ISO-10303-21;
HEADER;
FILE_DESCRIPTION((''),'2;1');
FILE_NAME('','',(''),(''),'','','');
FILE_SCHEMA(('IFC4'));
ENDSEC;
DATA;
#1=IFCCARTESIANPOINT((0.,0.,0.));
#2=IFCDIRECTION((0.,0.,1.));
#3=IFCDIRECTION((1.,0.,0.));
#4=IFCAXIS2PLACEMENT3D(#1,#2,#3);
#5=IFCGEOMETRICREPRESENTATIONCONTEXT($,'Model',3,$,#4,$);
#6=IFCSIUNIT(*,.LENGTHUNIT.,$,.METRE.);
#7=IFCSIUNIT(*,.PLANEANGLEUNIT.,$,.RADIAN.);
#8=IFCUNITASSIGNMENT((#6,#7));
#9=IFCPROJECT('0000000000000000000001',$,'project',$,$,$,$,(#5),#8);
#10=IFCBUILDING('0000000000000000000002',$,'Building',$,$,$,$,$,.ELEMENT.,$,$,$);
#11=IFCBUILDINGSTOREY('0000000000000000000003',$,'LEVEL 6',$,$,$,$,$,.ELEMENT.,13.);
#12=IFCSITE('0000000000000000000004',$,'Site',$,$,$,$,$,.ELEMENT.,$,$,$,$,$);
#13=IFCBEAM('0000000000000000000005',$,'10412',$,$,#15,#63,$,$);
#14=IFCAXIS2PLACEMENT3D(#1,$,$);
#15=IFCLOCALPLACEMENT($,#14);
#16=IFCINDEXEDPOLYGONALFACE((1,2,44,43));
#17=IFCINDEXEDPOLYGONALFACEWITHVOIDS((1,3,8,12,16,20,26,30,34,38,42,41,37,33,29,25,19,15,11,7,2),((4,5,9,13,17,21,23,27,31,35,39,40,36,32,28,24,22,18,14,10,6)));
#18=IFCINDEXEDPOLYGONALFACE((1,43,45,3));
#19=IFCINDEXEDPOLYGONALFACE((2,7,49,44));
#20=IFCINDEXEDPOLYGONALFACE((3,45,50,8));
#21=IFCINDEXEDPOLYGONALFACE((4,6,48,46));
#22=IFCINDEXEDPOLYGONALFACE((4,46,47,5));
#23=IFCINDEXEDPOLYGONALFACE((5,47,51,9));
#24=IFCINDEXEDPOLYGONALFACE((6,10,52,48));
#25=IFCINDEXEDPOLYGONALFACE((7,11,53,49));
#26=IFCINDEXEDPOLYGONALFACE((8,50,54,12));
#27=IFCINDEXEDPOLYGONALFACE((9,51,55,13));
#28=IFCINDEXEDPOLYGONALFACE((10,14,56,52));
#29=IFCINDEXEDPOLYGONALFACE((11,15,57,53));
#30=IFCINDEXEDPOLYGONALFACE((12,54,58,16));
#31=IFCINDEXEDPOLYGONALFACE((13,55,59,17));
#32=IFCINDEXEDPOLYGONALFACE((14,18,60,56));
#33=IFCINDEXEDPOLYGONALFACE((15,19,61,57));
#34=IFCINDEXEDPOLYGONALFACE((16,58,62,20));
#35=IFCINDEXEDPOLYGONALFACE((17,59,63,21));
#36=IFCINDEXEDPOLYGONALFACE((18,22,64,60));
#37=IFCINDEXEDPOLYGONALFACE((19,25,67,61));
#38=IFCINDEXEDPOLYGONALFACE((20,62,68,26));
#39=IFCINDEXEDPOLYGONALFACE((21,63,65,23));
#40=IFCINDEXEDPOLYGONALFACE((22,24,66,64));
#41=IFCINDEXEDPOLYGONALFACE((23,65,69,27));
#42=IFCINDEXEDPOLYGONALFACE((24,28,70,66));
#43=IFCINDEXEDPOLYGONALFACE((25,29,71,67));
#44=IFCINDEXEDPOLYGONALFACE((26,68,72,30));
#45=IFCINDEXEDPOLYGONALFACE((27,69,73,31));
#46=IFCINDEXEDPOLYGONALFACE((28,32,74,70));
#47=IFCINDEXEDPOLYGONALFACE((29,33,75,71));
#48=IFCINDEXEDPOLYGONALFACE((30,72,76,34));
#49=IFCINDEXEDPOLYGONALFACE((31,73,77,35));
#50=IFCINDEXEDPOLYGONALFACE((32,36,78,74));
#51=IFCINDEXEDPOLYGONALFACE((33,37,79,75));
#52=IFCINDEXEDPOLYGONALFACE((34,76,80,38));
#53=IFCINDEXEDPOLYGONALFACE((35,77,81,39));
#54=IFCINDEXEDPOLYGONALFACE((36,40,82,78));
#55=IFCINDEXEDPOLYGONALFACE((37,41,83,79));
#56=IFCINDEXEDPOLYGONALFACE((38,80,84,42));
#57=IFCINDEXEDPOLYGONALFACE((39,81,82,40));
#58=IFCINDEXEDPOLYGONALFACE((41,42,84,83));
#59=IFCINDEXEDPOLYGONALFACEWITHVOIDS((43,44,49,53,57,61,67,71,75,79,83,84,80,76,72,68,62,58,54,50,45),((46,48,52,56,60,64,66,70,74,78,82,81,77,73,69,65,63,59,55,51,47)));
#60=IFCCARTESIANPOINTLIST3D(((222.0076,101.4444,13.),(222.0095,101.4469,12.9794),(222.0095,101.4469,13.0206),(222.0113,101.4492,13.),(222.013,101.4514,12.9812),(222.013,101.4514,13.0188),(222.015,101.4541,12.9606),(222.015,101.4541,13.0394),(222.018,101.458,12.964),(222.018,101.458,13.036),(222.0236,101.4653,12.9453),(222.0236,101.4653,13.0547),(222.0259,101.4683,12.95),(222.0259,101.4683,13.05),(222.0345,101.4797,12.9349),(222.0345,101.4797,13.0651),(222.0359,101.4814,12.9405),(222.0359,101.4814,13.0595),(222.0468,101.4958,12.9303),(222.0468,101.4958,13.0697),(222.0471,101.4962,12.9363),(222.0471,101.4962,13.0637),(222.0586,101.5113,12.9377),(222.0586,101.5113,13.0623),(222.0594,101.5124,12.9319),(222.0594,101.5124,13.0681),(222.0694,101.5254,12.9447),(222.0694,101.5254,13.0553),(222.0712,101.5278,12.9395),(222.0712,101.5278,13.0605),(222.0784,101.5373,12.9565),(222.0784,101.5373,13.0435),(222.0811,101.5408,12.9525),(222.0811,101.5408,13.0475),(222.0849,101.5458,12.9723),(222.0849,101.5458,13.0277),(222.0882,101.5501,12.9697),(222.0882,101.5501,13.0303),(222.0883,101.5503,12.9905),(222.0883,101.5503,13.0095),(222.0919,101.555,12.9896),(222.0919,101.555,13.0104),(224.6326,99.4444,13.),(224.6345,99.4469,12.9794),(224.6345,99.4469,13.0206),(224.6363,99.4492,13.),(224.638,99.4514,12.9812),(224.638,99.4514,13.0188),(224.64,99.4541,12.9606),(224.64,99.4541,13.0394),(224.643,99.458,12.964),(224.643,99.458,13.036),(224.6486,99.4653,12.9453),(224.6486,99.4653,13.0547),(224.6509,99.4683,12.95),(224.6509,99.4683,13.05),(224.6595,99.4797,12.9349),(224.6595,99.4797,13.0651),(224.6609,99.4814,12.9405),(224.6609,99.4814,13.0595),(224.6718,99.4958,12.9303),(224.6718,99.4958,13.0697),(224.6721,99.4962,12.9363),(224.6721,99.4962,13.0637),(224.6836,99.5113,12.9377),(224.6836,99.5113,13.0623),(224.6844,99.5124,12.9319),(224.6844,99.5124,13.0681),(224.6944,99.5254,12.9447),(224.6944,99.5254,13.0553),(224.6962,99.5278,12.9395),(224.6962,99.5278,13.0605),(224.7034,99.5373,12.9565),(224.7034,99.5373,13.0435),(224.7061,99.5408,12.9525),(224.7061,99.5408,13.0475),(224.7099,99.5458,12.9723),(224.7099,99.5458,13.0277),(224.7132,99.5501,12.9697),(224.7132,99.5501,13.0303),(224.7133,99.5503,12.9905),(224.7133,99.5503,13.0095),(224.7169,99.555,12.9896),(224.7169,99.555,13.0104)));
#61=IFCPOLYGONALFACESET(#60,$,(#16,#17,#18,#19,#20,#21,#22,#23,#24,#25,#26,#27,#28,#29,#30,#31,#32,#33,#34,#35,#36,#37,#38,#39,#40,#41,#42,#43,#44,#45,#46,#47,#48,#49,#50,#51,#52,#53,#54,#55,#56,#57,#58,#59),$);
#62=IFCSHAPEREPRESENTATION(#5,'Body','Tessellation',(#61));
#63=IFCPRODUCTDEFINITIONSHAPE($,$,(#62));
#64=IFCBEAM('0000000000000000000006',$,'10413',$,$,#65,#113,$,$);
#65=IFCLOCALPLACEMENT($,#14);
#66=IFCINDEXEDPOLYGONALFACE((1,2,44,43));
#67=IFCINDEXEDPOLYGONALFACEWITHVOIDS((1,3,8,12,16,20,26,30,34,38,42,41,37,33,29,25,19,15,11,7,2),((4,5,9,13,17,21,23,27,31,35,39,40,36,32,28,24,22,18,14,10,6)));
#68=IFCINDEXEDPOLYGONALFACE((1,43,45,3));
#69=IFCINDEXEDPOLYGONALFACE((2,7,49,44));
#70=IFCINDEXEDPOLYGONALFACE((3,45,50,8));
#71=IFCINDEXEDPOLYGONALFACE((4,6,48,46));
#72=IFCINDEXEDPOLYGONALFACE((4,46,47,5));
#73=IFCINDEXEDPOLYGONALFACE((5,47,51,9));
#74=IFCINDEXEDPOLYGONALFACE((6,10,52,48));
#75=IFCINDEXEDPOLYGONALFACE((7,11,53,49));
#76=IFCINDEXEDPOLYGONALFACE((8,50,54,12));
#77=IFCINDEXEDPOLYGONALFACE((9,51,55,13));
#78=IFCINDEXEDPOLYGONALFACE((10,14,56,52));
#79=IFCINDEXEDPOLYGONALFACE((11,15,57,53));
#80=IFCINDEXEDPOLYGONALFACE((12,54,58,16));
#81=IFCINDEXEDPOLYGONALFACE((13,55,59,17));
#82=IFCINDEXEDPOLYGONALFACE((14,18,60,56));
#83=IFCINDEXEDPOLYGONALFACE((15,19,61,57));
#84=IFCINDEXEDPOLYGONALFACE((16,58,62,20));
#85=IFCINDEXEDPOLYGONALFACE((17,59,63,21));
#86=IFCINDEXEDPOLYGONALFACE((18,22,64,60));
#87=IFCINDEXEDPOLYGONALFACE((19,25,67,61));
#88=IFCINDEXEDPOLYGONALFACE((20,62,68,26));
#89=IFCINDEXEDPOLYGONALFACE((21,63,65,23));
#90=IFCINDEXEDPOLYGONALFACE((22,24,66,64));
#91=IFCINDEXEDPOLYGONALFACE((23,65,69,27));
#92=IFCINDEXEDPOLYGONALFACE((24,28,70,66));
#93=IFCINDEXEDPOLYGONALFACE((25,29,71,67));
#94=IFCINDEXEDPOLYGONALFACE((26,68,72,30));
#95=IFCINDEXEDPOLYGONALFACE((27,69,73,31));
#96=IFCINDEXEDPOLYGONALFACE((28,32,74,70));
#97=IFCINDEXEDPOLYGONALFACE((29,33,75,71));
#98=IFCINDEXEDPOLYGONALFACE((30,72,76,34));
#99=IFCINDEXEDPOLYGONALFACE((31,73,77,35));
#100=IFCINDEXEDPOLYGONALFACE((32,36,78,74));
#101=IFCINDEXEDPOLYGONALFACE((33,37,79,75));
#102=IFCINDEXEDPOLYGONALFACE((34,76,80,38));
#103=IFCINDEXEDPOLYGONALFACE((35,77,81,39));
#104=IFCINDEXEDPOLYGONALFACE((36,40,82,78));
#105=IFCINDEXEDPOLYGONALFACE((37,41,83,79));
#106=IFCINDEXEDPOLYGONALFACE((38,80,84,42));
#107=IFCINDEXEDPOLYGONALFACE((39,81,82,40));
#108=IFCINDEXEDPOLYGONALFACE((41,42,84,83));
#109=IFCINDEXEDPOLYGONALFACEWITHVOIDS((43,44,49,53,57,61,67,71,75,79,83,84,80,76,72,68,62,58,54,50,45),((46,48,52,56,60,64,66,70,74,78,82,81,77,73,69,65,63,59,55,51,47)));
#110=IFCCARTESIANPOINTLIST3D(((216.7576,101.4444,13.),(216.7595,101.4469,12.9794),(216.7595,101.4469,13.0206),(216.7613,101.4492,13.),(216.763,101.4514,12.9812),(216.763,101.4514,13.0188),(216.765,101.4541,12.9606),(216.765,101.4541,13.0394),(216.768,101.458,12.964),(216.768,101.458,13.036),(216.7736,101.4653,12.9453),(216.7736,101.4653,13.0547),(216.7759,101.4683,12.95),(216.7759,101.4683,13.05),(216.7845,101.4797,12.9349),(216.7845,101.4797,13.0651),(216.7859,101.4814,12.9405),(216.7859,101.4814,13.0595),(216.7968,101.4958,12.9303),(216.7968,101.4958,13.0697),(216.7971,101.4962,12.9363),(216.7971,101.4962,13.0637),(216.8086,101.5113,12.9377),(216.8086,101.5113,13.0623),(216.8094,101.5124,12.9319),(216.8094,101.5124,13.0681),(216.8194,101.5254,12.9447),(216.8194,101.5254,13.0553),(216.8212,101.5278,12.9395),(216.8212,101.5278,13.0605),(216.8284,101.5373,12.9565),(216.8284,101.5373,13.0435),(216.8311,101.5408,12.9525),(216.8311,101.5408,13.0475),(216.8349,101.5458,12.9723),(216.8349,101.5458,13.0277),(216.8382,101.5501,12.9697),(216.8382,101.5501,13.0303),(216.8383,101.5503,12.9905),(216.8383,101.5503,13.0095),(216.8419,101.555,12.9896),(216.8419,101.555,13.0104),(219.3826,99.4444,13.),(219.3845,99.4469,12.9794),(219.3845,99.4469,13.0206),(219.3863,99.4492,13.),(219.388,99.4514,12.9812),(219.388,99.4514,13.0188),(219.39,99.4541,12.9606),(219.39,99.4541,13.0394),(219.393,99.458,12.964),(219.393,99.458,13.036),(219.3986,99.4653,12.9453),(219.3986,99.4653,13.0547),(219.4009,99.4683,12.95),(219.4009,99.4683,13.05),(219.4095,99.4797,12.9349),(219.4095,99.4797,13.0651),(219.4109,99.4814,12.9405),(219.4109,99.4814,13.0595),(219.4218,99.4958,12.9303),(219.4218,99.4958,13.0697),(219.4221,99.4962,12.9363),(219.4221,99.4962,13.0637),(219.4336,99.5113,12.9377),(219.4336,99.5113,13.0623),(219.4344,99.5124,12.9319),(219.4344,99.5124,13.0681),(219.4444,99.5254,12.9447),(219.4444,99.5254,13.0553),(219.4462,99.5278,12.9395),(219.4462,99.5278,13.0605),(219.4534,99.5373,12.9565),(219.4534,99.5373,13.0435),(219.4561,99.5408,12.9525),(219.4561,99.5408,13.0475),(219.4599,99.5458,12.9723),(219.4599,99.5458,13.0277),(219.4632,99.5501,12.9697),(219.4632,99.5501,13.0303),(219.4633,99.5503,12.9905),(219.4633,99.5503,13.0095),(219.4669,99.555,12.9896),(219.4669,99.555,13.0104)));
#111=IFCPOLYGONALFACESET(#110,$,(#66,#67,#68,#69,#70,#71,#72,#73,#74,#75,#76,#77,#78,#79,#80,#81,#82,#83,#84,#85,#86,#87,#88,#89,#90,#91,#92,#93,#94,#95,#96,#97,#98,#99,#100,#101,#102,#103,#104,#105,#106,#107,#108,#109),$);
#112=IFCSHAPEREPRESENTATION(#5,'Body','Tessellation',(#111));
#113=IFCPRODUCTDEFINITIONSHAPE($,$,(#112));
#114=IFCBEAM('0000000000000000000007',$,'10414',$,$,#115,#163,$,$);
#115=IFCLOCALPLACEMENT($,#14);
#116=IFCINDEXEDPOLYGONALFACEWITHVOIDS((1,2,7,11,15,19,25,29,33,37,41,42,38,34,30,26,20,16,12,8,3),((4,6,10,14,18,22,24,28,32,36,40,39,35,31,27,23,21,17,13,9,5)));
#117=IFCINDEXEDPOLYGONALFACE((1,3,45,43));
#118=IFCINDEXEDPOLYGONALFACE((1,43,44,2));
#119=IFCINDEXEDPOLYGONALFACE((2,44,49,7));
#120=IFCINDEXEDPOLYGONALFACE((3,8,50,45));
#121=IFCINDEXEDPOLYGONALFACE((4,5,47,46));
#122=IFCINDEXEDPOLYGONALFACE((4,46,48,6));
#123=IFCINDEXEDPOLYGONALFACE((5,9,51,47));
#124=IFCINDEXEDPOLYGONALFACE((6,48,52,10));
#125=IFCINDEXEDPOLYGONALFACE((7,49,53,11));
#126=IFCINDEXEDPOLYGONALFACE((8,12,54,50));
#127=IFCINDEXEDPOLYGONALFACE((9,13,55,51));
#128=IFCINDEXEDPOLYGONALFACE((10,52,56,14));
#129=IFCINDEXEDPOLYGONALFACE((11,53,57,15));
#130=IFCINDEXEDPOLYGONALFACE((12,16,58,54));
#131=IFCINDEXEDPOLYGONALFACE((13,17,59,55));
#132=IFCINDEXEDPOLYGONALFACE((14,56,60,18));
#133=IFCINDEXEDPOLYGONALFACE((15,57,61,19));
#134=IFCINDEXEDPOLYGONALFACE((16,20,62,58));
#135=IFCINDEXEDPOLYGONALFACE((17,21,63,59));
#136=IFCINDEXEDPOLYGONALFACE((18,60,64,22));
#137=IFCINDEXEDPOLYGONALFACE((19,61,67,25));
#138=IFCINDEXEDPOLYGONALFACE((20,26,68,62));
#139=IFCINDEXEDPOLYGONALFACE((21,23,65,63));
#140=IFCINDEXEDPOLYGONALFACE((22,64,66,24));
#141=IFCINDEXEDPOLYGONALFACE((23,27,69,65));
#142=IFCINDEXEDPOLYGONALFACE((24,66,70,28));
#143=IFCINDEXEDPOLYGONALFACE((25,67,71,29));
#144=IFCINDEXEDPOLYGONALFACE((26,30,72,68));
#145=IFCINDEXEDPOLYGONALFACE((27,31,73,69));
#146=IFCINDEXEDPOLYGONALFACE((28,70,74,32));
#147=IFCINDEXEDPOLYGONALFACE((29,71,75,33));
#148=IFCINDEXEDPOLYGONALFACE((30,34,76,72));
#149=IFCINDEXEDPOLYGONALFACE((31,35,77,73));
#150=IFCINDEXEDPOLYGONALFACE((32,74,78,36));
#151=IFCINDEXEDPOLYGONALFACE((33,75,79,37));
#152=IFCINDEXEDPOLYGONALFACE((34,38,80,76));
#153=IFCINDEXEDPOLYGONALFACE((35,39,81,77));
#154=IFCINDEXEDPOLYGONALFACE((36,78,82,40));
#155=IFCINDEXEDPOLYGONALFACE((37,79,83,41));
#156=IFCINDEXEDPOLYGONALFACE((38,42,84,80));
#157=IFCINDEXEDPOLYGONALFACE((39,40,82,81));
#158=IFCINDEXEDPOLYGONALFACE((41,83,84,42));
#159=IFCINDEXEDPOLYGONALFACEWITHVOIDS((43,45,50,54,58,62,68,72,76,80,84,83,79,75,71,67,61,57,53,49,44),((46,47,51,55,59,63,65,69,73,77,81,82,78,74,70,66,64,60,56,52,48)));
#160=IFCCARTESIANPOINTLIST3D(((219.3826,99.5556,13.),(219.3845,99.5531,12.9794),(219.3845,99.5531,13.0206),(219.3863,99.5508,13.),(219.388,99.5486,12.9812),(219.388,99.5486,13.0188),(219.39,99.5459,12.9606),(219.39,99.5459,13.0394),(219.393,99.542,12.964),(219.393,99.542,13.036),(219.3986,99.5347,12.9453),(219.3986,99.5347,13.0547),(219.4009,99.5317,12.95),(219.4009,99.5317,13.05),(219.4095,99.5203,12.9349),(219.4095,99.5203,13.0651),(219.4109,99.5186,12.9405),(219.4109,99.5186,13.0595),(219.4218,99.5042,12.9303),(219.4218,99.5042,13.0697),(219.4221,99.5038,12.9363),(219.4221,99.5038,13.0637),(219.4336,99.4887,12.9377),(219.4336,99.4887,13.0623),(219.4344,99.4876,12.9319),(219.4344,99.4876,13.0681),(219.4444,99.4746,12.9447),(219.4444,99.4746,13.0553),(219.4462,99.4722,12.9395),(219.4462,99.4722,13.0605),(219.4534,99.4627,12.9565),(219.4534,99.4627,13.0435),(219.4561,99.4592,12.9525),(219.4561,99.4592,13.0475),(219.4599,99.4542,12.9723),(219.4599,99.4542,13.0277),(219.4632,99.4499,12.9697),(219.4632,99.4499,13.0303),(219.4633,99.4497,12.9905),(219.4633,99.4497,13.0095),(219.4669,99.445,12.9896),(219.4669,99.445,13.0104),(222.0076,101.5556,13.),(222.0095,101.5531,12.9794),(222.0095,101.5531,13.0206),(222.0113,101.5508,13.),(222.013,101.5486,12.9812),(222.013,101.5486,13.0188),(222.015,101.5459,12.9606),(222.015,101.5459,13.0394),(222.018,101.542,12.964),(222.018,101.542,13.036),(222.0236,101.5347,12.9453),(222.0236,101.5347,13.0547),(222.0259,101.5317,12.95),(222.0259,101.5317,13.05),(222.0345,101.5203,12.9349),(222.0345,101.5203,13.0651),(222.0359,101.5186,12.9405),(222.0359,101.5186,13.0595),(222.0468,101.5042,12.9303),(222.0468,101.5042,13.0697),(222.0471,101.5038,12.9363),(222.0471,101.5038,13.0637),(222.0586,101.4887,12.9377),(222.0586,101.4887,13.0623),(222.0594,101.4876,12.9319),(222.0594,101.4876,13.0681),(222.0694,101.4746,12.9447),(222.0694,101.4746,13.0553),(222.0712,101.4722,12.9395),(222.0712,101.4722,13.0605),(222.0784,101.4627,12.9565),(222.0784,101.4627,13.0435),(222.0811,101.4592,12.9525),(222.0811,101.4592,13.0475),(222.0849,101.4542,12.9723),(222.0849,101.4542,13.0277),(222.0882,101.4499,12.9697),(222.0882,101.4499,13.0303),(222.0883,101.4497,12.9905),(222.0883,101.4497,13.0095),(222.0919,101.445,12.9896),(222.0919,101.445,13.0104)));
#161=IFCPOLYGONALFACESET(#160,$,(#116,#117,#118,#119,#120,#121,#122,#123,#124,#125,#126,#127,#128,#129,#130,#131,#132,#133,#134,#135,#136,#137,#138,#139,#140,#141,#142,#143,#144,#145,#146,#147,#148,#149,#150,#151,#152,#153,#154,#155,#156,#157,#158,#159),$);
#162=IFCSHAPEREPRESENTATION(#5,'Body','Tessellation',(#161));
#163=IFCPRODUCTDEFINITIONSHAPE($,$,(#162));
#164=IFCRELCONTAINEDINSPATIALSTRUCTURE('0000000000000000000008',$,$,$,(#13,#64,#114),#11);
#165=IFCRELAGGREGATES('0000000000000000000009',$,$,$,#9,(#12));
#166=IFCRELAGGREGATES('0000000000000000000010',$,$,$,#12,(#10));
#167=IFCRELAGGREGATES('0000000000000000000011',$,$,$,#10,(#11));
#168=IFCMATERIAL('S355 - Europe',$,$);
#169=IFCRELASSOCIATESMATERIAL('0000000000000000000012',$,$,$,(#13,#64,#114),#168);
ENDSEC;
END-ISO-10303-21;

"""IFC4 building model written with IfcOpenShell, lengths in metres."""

from ifc_helpers import new_model, si_unit, frame, origin_with_axes, origin_2d_with_axis, place, context, project, spatial, hollow_circle, extrude, material, material_profile, profile_set, profile_usage, element, save


model = new_model("IFC4")

# Units and contexts
model_context = context("Model", 3, world=origin_with_axes())
ifc_project = project(units=[si_unit("LENGTHUNIT", "METRE"), si_unit("PLANEANGLEUNIT", "RADIAN")], contexts=[model_context])

# Site, building, storey
site = spatial("IfcSite", under=ifc_project, Name="Site", CompositionType="ELEMENT")
building = spatial("IfcBuilding", under=site, Name="Building", CompositionType="ELEMENT")
storey = spatial("IfcBuildingStorey", under=building, Name="LEVEL 6", CompositionType="ELEMENT", Elevation=13.0)

# Shared definitions
ifc_material = material(Name="S355 - Europe")

# Beams
ifc_material_profile_1 = material_profile(ifc_material, hollow_circle(Radius=0.0699, WallThickness=0.006, at=origin_2d_with_axis()))
ifc_profile_set_1 = profile_set([ifc_material_profile_1])
ifc_profile_usage_1 = profile_usage(ifc_profile_set_1, cardinal=10)
beam_1_placement = place(None, frame((224.675, 99.5, 13.0), z_axis=(-0.795432, 0.606043, 0.0), x_axis=(-0.606043, -0.795432, 0.0)))
element("IfcBeam", 1, at=beam_1_placement, inside=storey, material=ifc_profile_usage_1, Name="10412", context=model_context, shape_type="SweptSolid", body=[
    extrude(hollow_circle(Radius=0.0699, WallThickness=0.006, at=origin_2d_with_axis()), origin_with_axes(), (0.0, 0.0, 1.0), 3.3001),
])
ifc_material_profile_2 = material_profile(ifc_material, hollow_circle(Radius=0.0699, WallThickness=0.006, at=origin_2d_with_axis()))
ifc_profile_set_2 = profile_set([ifc_material_profile_2])
ifc_profile_usage_2 = profile_usage(ifc_profile_set_2, cardinal=10)
beam_2_placement = place(None, frame((219.425, 99.5, 13.0), z_axis=(-0.795432, 0.606043, 0.0), x_axis=(-0.606043, -0.795432, 0.0)))
element("IfcBeam", 2, at=beam_2_placement, inside=storey, material=ifc_profile_usage_2, Name="10413", context=model_context, shape_type="SweptSolid", body=[
    extrude(hollow_circle(Radius=0.0699, WallThickness=0.006, at=origin_2d_with_axis()), origin_with_axes(), (0.0, 0.0, 1.0), 3.3001),
])
ifc_material_profile_3 = material_profile(ifc_material, hollow_circle(Radius=0.0699, WallThickness=0.006, at=origin_2d_with_axis()))
ifc_profile_set_3 = profile_set([ifc_material_profile_3])
ifc_profile_usage_3 = profile_usage(ifc_profile_set_3, cardinal=10)
beam_3_placement = place(None, frame((219.425, 99.5, 13.0), z_axis=(0.795432, 0.606043, 0.0), x_axis=(-0.606043, 0.795432, 0.0)))
element("IfcBeam", 3, at=beam_3_placement, inside=storey, material=ifc_profile_usage_3, Name="10414", context=model_context, shape_type="SweptSolid", body=[
    extrude(hollow_circle(Radius=0.0699, WallThickness=0.006, at=origin_2d_with_axis()), origin_with_axes(), (0.0, 0.0, 1.0), 3.3001),
])

save(model, "model.ifc")
